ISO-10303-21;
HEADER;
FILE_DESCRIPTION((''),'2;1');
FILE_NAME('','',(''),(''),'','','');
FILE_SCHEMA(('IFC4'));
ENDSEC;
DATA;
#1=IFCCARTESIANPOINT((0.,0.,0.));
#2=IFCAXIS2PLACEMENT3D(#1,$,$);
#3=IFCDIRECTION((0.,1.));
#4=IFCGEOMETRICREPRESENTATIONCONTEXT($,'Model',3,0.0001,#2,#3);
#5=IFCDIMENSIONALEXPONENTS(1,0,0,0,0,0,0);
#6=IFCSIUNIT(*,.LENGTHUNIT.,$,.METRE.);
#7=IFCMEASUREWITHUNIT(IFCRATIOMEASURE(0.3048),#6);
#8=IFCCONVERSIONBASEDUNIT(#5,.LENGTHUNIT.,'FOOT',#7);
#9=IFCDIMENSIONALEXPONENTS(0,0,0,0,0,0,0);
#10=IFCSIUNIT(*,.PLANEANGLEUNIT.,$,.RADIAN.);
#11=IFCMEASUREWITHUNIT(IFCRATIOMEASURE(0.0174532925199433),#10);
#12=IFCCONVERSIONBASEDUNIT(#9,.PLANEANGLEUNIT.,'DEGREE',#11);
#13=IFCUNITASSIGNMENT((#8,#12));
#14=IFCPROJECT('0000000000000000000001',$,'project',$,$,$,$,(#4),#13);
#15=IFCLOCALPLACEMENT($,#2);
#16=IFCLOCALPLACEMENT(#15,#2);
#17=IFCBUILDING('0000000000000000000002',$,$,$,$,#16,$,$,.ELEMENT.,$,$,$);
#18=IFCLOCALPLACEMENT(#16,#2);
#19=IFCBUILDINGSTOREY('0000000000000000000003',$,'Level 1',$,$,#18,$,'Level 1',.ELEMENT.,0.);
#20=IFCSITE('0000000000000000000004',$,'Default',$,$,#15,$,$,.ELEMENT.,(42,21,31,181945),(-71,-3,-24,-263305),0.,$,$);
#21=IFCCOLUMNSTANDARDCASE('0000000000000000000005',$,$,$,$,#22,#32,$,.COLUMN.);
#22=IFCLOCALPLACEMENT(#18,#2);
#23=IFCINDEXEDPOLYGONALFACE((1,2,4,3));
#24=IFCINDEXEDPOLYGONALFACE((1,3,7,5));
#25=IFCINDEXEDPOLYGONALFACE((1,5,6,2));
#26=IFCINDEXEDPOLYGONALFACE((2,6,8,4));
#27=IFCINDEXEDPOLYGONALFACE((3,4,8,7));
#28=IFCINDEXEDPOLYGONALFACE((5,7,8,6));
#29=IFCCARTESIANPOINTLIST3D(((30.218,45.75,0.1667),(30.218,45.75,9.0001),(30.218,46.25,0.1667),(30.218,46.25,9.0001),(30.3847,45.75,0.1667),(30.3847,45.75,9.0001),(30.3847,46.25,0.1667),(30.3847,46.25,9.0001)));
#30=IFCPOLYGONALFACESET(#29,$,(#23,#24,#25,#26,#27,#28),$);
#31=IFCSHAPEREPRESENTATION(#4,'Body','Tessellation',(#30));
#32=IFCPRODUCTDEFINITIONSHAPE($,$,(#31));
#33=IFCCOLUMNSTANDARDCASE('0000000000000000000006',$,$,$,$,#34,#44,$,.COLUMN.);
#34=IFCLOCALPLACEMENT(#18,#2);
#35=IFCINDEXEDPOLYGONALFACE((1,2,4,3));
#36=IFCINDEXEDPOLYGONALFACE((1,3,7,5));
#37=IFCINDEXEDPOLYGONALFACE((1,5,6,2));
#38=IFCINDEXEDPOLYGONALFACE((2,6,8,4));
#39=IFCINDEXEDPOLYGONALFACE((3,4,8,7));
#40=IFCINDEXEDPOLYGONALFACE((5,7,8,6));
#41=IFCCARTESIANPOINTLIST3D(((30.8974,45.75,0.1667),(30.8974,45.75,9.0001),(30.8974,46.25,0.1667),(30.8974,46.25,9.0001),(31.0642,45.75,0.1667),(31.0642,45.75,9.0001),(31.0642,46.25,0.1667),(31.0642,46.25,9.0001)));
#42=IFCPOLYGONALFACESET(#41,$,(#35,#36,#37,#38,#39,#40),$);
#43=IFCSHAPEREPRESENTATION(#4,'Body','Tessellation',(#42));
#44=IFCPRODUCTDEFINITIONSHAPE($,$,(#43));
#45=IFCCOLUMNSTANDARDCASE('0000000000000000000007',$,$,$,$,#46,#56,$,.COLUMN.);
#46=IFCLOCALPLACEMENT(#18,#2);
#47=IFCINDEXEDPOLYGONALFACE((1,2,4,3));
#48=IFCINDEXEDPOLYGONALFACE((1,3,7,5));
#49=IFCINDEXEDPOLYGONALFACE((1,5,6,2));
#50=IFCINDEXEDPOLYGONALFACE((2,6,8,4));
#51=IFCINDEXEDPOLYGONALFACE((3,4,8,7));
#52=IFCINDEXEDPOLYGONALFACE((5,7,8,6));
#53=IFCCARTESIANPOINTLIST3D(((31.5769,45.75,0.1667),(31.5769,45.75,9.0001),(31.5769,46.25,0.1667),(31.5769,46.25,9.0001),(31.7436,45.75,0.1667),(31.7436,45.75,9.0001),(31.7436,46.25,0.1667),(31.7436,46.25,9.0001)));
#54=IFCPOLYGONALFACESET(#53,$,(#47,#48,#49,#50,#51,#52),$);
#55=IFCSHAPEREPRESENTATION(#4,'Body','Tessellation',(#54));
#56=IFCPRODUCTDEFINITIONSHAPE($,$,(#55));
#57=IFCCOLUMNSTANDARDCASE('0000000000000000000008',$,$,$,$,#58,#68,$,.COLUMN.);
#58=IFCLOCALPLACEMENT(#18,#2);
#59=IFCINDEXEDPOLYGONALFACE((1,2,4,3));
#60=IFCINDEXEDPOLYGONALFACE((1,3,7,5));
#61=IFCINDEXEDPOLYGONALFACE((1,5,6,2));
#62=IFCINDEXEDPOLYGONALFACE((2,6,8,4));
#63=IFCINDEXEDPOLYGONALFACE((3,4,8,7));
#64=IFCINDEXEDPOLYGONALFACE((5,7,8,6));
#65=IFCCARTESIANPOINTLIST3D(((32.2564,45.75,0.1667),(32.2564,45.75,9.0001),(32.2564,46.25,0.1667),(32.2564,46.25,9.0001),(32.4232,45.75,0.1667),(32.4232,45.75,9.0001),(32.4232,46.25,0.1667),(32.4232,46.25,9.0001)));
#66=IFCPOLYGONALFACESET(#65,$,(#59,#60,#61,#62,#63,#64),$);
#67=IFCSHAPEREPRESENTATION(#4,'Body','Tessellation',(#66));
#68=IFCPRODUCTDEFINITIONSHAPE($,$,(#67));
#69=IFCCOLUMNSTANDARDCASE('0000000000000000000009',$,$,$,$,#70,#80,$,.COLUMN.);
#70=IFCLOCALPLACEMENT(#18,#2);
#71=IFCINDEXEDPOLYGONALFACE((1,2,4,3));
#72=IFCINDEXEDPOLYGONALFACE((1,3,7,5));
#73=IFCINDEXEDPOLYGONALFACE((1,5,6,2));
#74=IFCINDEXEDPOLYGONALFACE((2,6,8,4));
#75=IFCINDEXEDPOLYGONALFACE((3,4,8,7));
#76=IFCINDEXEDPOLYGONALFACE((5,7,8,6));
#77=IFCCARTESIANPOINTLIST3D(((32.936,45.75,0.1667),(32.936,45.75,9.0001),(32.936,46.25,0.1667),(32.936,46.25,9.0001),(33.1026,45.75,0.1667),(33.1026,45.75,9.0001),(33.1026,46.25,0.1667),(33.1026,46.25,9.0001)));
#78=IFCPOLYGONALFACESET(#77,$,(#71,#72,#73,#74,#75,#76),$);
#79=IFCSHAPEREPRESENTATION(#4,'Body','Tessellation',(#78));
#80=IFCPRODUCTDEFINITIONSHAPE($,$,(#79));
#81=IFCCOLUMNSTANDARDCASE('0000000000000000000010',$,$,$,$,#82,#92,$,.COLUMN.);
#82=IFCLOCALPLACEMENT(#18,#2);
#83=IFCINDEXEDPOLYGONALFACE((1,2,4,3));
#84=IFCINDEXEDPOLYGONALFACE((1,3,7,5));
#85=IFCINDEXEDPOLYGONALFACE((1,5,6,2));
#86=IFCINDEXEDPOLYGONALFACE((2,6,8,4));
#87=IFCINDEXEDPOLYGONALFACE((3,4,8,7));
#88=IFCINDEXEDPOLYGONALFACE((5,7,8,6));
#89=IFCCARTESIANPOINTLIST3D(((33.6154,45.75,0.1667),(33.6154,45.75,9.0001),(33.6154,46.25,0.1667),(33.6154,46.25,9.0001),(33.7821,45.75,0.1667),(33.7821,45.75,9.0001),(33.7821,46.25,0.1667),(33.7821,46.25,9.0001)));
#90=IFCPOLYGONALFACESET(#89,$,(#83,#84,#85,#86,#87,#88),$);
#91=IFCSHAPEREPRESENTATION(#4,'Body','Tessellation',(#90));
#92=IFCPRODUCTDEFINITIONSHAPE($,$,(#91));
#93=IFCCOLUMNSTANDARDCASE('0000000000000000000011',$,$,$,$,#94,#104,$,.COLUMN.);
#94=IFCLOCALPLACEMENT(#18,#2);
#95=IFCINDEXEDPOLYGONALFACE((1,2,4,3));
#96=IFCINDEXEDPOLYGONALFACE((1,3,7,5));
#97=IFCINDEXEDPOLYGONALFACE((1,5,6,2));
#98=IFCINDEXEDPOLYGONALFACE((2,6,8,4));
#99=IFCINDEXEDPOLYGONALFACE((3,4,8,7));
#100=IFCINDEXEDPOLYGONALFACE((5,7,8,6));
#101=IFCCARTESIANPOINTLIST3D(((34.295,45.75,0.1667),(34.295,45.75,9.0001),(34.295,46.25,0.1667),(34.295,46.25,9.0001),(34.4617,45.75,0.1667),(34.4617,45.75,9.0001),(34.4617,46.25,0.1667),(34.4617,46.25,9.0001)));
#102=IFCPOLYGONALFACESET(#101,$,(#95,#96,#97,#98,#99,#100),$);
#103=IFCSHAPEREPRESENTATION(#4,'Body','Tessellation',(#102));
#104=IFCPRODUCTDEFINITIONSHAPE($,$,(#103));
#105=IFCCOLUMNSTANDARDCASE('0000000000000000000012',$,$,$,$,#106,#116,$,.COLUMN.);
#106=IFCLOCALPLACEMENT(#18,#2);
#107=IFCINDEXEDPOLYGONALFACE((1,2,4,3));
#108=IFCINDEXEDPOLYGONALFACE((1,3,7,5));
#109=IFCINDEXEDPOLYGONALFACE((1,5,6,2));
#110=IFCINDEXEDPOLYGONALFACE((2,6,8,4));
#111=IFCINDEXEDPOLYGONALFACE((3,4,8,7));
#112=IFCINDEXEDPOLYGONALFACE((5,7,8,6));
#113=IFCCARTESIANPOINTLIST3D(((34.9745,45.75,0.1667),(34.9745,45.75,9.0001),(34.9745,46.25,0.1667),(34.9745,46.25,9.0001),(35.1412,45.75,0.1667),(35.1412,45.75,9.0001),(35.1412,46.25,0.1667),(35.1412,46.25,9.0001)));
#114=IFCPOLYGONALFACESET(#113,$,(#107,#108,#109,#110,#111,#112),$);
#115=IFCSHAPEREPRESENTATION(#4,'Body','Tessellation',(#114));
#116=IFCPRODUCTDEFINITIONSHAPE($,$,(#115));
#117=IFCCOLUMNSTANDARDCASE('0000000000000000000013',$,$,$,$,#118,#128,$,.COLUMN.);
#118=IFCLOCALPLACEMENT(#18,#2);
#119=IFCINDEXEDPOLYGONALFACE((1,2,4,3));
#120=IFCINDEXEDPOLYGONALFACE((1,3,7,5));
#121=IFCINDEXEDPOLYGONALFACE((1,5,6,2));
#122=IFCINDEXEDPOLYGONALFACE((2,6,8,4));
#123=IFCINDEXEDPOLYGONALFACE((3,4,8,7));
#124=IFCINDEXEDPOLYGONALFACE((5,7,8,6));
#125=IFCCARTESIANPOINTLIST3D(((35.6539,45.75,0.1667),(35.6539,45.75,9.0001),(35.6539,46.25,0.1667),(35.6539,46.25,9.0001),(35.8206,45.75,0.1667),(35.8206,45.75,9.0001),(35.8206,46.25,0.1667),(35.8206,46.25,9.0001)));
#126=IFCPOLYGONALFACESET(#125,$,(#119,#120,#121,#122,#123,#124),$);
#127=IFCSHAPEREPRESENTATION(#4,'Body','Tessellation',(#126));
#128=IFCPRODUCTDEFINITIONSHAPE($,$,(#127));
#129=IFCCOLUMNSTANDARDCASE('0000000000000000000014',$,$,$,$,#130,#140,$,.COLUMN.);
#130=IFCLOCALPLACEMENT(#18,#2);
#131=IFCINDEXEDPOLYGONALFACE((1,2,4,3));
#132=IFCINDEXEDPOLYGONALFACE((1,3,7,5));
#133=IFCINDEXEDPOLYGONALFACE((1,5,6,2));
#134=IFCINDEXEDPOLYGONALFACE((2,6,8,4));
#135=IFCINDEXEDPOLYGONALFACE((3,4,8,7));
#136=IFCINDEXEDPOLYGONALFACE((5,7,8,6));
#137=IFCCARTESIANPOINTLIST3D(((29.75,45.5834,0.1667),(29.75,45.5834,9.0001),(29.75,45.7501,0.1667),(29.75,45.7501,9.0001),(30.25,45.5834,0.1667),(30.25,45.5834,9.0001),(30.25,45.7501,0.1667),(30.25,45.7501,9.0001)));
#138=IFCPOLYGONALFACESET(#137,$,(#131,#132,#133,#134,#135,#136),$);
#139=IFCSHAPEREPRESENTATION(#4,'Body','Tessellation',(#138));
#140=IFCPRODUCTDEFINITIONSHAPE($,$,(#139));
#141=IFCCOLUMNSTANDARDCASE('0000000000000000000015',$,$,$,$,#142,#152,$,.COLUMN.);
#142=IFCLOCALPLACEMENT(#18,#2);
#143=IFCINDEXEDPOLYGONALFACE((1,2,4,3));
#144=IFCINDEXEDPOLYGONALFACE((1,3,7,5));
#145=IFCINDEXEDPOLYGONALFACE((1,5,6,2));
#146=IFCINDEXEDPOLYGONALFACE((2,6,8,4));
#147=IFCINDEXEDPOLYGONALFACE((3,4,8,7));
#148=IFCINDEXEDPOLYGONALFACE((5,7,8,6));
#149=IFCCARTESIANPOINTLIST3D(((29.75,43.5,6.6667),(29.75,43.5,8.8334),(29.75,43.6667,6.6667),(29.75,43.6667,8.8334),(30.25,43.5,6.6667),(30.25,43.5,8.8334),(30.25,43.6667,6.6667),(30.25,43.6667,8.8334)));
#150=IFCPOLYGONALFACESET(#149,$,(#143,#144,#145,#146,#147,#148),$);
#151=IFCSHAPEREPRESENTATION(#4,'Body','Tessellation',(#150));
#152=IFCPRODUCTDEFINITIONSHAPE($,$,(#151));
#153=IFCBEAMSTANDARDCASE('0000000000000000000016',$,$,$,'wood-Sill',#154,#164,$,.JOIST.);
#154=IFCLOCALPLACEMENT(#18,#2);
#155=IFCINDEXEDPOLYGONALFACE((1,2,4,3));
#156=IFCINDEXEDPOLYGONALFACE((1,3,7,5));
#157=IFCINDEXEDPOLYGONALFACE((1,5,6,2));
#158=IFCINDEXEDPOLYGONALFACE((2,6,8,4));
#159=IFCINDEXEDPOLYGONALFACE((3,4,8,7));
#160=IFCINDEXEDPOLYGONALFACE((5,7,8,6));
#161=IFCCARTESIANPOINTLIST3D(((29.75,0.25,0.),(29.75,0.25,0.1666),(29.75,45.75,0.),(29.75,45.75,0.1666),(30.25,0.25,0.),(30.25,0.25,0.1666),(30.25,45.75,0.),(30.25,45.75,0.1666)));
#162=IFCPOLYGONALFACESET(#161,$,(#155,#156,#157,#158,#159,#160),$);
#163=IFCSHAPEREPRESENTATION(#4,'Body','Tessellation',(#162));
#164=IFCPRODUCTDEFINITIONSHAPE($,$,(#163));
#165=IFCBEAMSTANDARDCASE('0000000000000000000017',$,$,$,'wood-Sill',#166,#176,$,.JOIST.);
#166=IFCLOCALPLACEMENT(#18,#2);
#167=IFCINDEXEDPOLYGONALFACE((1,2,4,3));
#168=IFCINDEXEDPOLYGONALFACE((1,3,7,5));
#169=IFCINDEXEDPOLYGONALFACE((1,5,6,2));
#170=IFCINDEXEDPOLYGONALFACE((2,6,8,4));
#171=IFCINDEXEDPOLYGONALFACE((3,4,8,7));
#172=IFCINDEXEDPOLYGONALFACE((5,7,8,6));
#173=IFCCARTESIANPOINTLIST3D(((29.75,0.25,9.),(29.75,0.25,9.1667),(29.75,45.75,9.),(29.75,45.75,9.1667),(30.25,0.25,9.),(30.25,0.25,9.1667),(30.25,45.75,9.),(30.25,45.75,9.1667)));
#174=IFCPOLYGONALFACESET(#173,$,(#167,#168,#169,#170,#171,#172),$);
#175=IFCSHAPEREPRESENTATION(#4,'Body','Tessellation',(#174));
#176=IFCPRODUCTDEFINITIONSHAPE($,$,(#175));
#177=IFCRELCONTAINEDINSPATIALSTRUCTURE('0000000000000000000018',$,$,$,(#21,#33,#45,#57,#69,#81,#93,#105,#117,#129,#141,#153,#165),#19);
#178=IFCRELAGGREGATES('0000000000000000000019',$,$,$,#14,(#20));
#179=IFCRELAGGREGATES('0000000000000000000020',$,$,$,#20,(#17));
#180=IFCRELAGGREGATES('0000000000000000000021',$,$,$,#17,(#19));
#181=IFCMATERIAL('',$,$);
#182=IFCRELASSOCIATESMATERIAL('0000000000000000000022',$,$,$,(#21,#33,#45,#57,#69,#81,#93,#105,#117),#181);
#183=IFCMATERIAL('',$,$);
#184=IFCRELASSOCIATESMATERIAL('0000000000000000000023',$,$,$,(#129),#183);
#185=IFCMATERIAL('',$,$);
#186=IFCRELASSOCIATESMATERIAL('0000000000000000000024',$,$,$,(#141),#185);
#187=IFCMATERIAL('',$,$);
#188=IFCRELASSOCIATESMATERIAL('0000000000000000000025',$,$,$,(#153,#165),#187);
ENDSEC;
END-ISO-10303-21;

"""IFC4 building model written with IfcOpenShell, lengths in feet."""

from ifc_helpers import new_model, entity, si_unit, converted_unit, direction, frame, origin, origin_with_axes, place, context, project, spatial, rectangle, extrude, material, element, save


model = new_model("IFC4")

# Units and contexts
model_context = context("Model", 3, precision=0.0001, world=origin(), true_north=direction((0.0, 1.0)))
ifc_project = project(units=[converted_unit("LENGTHUNIT", "FOOT", entity("IfcRatioMeasure", 0.3048), si_unit("LENGTHUNIT", "METRE"), dimensions=[1, 0, 0, 0, 0, 0, 0]), converted_unit("PLANEANGLEUNIT", "DEGREE", entity("IfcRatioMeasure", 0.0174532925199433), si_unit("PLANEANGLEUNIT", "RADIAN"), dimensions=[0, 0, 0, 0, 0, 0, 0])], contexts=[model_context])

# Site, building, storey
site_placement = place(None, origin())
site = spatial("IfcSite", under=ifc_project, at=site_placement, Name="Default", CompositionType="ELEMENT", RefLatitude=(42, 21, 31, 181945), RefLongitude=(-71, -3, -24, -263305), RefElevation=0.0)
building_placement = place(site_placement, origin())
building = spatial("IfcBuilding", under=site, at=building_placement, CompositionType="ELEMENT")
storey_placement = place(building_placement, origin())
storey = spatial("IfcBuildingStorey", under=building, at=storey_placement, Name="Level 1", LongName="Level 1", CompositionType="ELEMENT", Elevation=0.0)

# Columns
ifc_material_1 = material(Name="")
placement_1 = place(storey_placement, frame((-0.25, 46.0, 0.0)))
for number, where, z_axis, x_axis in (
    (1, (30.5513, 0.0, 0.1667), (0.0, 0.0, 1.0), (1.0, 0.0, 0.0)),
    (2, (31.2308, 0.0, 0.1667), (0.0, 0.0, 1.0), (1.0, 0.0, 0.0)),
    (3, (31.9103, 0.0, 0.1667), (0.0, 0.0, 1.0), (1.0, 0.0, 0.0)),
    (4, (32.5898, 0.0, 0.1667), (0.0, 0.0, 1.0), (1.0, 0.0, 0.0)),
    (5, (33.2693, 0.0, 0.1667), (0.0, 0.0, 1.0), (1.0, 0.0, 0.0)),
    (6, (33.9488, 0.0, 0.1667), (0.0, 0.0, 1.0), (1.0, 0.0, 0.0)),
    (7, (34.6283, 0.0, 0.1667), (0.0, 0.0, 1.0), (1.0, 0.0, 0.0)),
    (8, (35.3078, 0.0, 0.1667), (0.0, 0.0, 1.0), (1.0, 0.0, 0.0)),
    (9, (35.9873, 0.0, 0.1667), (0.0, 0.0, 1.0), (1.0, 0.0, 0.0)),
):
    element("IfcColumnStandardCase", number, at=place(placement_1, frame(where, z_axis=z_axis, x_axis=x_axis)), inside=storey, material=ifc_material_1, PredefinedType="COLUMN", context=model_context, shape_type="SweptSolid", body=[
        extrude(rectangle(XDim=0.1667, YDim=0.5), origin(), (0.0, 0.0, 1.0), 8.8334),
    ])
ifc_material_2 = material(Name="")
placement_2 = place(storey_placement, frame((30.0, 45.75, 0.0), z_axis=(0.0, 0.0, 1.0), x_axis=(0.0, -1.0, 0.0)))
for number, where, z_axis, x_axis in (
    (10, (0.0833, 0.0, 0.1667), (0.0, 0.0, 1.0), (1.0, 0.0, 0.0)),
):
    element("IfcColumnStandardCase", number, at=place(placement_2, frame(where, z_axis=z_axis, x_axis=x_axis)), inside=storey, material=ifc_material_2, PredefinedType="COLUMN", context=model_context, shape_type="SweptSolid", body=[
        extrude(rectangle(XDim=0.1667, YDim=0.5), origin(), (0.0, 0.0, 1.0), 8.8334),
    ])
ifc_material_3 = material(Name="")
for number, where, z_axis, x_axis in (
    (11, (2.1667, 0.0, 6.6667), (0.0, 0.0, 1.0), (1.0, 0.0, 0.0)),
):
    element("IfcColumnStandardCase", number, at=place(placement_2, frame(where, z_axis=z_axis, x_axis=x_axis)), inside=storey, material=ifc_material_3, PredefinedType="COLUMN", context=model_context, shape_type="SweptSolid", body=[
        extrude(rectangle(XDim=0.1667, YDim=0.5), origin(), (0.0, 0.0, 1.0), 2.1667),
    ])

# Beams
ifc_material_4 = material(Name="")
for number, where, z_axis, x_axis in (
    (12, (0.0, 0.0, 0.0833), (1.0, 0.0, 0.0), (0.0, 0.0, 1.0)),
    (13, (0.0, 0.0, 9.0834), (1.0, 0.0, 0.0), (0.0, 0.0, 1.0)),
):
    element("IfcBeamStandardCase", number, at=place(placement_2, frame(where, z_axis=z_axis, x_axis=x_axis)), inside=storey, material=ifc_material_4, ObjectType="wood-Sill", PredefinedType="JOIST", context=model_context, shape_type="SweptSolid", body=[
        extrude(rectangle(XDim=0.1667, YDim=0.5), origin_with_axes(), (0.0, 0.0, 1.0), 45.5),
    ])

save(model, "model.ifc")
